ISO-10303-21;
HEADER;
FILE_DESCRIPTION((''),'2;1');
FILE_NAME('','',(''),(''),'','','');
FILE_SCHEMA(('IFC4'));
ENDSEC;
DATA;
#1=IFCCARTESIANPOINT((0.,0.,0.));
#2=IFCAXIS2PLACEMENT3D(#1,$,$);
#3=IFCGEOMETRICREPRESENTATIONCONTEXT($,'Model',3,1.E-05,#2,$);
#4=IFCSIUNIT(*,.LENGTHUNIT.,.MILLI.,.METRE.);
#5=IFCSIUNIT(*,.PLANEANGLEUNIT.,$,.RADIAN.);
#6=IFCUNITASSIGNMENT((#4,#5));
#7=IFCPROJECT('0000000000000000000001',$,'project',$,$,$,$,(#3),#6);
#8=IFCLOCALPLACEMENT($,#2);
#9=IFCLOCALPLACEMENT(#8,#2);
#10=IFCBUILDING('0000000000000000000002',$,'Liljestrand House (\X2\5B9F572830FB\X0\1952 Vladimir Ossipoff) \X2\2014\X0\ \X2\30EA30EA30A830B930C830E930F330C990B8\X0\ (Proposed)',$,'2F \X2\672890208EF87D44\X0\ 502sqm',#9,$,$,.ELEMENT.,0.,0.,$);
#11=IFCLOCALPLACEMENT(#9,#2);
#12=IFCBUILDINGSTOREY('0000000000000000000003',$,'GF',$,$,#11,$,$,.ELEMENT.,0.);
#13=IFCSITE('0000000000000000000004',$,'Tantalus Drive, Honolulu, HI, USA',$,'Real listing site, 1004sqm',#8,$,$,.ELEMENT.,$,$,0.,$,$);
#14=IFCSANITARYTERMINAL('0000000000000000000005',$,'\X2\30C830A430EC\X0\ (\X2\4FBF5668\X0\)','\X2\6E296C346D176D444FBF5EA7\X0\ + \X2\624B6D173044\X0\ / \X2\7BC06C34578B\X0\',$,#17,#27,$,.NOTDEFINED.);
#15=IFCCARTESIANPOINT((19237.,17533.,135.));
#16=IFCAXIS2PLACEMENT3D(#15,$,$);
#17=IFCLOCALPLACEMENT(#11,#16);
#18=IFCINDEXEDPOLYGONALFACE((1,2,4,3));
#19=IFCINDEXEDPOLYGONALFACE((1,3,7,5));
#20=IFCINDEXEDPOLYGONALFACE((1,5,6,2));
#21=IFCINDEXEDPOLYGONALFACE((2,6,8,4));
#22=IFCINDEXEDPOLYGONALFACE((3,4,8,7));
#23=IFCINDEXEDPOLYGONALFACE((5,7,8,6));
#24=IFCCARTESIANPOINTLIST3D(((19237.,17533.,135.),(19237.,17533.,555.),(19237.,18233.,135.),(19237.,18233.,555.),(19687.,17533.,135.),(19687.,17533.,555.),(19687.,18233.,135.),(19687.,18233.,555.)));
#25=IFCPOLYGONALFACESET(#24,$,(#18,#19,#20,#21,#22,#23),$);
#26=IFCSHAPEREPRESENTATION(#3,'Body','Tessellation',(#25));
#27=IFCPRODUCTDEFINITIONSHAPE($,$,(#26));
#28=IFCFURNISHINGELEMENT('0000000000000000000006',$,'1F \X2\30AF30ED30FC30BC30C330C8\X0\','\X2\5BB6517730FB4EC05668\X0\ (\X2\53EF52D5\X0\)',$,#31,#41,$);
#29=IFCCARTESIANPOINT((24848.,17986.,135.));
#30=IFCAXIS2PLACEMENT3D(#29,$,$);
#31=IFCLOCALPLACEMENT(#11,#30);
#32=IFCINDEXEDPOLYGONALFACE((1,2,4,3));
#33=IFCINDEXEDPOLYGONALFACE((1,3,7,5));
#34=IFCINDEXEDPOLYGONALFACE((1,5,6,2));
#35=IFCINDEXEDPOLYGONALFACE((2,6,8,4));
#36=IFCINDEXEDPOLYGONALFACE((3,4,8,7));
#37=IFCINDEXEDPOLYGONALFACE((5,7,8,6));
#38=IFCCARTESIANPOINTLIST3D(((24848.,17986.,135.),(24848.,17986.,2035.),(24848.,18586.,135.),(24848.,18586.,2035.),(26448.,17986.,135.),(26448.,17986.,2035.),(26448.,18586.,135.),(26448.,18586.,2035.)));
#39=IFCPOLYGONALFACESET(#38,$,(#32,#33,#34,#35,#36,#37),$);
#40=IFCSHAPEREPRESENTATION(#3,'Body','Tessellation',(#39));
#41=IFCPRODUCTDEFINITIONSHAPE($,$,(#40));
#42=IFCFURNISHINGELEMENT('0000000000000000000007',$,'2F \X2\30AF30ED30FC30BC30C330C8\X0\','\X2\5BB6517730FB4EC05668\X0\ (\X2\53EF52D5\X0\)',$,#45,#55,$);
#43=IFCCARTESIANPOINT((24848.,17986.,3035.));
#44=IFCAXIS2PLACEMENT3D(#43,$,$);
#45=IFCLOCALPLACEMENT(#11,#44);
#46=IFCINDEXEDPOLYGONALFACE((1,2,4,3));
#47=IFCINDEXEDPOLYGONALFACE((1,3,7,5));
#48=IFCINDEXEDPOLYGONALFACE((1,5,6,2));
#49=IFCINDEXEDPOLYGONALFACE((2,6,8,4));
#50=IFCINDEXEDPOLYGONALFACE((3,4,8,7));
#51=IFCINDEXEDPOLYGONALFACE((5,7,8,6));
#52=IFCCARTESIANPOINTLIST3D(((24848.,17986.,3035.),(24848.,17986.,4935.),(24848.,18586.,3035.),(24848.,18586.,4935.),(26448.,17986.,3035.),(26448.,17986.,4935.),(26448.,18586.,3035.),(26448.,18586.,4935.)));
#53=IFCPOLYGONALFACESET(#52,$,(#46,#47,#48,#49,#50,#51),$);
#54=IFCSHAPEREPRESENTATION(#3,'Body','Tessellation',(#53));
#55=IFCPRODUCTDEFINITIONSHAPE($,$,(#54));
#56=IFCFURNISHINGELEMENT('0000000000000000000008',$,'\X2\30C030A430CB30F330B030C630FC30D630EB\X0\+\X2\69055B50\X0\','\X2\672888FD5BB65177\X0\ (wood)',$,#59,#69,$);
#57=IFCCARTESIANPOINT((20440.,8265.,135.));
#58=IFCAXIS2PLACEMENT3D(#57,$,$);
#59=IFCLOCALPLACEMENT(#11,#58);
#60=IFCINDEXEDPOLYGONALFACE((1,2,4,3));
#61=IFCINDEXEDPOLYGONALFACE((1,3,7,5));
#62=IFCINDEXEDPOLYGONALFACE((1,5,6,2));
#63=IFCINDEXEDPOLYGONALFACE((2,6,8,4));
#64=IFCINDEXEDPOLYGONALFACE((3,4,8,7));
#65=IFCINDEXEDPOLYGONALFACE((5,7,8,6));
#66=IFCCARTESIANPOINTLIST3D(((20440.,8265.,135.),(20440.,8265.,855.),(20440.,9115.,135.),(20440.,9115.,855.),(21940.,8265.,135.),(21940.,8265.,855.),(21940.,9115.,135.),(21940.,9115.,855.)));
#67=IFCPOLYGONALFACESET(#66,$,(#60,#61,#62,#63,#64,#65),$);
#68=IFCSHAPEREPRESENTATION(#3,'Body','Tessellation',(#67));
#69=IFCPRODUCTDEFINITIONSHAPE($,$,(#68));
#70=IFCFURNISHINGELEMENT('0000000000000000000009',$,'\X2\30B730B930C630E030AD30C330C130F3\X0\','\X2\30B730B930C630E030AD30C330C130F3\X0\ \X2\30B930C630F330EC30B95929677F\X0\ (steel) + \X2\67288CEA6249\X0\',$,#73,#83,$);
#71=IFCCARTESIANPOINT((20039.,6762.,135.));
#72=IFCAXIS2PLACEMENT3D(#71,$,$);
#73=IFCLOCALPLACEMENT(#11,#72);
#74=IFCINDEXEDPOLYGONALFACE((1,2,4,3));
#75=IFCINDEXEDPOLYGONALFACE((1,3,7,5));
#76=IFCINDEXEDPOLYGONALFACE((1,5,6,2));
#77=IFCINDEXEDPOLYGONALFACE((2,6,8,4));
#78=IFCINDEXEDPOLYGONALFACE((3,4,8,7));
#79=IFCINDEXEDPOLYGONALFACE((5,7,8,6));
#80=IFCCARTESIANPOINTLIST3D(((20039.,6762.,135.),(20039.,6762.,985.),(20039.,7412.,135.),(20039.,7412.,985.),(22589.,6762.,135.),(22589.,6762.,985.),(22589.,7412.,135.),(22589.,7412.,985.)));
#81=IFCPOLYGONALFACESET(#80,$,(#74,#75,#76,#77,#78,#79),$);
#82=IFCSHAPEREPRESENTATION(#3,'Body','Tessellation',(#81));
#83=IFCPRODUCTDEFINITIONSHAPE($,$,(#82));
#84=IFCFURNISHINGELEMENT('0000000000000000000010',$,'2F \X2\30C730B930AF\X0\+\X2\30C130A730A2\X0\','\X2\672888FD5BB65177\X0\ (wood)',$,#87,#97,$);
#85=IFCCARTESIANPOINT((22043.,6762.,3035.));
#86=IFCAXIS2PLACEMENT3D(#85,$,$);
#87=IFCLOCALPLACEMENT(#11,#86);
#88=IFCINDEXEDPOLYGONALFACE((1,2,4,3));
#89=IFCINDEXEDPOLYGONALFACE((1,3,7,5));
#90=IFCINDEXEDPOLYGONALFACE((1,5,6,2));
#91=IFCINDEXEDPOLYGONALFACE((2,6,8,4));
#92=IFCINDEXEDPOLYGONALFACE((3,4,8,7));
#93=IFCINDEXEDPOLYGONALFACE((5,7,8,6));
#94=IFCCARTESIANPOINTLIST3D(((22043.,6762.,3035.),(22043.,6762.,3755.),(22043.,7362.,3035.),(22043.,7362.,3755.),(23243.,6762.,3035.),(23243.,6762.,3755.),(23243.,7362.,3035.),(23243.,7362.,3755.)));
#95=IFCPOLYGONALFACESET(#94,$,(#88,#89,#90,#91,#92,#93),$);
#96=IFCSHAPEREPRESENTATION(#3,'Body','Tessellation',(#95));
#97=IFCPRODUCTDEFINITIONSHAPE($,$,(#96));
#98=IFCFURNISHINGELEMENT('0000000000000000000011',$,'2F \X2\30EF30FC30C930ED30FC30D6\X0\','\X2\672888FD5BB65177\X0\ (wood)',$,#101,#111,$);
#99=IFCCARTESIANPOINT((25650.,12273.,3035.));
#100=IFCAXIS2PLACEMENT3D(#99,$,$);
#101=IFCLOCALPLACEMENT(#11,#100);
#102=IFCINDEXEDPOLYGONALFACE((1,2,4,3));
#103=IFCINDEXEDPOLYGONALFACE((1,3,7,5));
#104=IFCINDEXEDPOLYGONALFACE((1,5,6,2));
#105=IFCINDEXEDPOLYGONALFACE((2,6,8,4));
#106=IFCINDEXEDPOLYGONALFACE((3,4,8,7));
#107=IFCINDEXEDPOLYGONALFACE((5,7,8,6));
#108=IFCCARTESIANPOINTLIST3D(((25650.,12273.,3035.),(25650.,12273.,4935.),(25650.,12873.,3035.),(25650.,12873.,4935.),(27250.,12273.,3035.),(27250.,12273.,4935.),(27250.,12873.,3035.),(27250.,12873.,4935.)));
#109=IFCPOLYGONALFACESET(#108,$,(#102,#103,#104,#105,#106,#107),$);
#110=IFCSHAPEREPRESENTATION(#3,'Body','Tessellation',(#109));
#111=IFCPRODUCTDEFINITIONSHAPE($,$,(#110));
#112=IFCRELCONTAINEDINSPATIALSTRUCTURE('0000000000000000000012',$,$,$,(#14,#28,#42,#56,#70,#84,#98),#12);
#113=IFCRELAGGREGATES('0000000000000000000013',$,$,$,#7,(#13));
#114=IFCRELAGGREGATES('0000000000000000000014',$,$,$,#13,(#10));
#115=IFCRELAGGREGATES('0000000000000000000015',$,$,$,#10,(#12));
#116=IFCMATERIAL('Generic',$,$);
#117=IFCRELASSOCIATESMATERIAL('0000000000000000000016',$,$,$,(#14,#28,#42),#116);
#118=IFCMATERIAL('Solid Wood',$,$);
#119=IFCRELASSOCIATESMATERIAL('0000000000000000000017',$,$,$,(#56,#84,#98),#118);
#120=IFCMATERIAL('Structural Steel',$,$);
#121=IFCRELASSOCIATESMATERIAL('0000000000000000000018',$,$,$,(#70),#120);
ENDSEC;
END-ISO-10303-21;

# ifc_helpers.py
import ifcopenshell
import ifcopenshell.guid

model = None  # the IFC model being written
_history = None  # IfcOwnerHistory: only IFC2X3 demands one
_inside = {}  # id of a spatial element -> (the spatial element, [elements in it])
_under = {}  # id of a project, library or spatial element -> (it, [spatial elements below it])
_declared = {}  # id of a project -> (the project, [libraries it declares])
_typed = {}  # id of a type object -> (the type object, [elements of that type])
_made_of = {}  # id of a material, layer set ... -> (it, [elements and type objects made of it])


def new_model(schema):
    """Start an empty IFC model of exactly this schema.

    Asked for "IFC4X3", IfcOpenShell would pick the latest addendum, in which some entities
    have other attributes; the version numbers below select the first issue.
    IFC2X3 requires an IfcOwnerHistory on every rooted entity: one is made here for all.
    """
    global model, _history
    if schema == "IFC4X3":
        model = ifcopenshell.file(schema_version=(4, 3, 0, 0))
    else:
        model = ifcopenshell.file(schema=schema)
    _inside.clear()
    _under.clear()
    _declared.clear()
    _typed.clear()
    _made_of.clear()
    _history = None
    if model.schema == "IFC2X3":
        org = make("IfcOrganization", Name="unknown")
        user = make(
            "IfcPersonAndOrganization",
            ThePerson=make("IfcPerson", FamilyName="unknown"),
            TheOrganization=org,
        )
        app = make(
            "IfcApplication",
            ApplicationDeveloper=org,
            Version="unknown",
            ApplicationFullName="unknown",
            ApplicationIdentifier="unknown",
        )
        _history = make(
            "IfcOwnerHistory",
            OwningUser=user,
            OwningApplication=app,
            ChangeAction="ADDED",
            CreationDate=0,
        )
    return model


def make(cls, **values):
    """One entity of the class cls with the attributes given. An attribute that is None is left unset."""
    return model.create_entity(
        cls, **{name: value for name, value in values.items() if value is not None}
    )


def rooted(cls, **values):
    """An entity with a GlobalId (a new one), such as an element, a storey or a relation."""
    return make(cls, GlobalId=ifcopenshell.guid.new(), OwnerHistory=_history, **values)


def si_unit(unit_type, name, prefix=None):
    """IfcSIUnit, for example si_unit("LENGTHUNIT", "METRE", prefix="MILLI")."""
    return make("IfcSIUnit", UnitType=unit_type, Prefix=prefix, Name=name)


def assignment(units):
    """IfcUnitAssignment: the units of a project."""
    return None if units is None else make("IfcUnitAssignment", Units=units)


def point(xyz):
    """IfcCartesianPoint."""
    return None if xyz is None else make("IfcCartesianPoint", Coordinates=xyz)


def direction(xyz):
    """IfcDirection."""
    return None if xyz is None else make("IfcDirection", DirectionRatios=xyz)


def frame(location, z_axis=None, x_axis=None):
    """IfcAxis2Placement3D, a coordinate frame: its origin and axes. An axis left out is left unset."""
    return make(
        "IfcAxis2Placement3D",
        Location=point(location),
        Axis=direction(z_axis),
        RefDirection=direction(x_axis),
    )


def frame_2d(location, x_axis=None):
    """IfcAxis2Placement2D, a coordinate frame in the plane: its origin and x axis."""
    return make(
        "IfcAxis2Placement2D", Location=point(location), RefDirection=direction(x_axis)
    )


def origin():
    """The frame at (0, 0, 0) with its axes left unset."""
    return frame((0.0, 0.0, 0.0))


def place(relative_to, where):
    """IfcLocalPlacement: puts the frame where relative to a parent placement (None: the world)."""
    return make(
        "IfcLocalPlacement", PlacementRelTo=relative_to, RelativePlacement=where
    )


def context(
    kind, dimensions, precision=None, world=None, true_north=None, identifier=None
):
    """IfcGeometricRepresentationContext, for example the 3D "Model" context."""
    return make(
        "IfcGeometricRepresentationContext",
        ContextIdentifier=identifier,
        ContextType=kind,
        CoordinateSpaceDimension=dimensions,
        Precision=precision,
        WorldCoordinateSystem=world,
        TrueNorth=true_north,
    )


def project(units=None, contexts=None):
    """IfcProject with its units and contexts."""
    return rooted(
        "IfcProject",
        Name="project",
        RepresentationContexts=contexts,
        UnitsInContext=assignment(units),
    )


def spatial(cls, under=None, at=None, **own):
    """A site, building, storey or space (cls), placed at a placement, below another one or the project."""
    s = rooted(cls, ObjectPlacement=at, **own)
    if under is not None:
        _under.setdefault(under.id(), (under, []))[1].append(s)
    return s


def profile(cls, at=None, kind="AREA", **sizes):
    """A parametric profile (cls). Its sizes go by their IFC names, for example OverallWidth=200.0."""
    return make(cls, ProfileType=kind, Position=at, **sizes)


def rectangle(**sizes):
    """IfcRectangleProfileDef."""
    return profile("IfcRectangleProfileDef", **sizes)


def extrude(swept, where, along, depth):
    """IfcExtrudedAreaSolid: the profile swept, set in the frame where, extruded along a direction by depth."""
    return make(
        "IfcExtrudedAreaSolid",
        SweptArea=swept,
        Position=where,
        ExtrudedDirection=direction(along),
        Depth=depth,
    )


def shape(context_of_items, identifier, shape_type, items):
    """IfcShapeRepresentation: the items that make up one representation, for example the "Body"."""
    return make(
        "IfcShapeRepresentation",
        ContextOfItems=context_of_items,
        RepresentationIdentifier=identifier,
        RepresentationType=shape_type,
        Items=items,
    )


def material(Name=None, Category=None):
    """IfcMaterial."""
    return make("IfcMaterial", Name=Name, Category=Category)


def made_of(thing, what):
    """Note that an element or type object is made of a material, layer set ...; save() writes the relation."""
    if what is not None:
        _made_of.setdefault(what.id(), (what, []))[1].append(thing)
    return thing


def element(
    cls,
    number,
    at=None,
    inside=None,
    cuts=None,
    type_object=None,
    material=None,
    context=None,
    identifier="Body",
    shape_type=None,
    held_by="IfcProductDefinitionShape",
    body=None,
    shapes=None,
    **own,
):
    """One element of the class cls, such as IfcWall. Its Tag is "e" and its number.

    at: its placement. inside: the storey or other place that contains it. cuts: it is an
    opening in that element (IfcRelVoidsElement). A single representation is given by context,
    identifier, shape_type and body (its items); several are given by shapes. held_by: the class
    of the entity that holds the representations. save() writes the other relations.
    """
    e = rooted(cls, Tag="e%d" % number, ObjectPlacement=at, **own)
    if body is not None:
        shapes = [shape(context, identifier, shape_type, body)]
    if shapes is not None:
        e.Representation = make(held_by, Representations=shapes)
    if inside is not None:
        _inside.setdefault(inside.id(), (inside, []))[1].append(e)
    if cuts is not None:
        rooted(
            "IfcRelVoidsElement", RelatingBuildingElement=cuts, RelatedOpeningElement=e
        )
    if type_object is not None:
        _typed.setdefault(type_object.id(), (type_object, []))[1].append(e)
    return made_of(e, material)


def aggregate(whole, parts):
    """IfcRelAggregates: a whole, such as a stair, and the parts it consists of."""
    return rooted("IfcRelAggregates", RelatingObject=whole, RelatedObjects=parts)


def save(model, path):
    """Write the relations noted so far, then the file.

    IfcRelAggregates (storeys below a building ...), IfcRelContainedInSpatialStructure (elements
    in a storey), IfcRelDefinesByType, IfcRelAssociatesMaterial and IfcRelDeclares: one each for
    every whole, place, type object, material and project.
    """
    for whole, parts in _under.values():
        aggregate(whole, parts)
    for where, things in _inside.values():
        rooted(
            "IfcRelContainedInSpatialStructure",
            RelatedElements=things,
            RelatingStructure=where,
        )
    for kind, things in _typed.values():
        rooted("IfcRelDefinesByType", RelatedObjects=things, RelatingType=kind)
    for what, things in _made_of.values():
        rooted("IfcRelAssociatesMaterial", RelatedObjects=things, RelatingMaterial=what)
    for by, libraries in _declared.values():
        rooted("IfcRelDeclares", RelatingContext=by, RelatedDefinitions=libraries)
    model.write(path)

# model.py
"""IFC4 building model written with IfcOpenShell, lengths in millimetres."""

from ifc_helpers import new_model, si_unit, frame, frame_2d, origin, place, context, project, spatial, rectangle, extrude, material, element, save


model = new_model("IFC4")

# Units and contexts
model_context = context("Model", 3, precision=1e-05, world=origin())
ifc_project = project(units=[si_unit("LENGTHUNIT", "METRE", prefix="MILLI"), si_unit("PLANEANGLEUNIT", "RADIAN")], contexts=[model_context])

# Site, building, storey
site_placement = place(None, origin())
site = spatial("IfcSite", under=ifc_project, at=site_placement, Name="Tantalus Drive, Honolulu, HI, USA", ObjectType="Real listing site, 1004sqm", CompositionType="ELEMENT", RefElevation=0.0)
building_placement = place(site_placement, origin())
building = spatial("IfcBuilding", under=site, at=building_placement, Name="Liljestrand House (実在・1952 Vladimir Ossipoff) — リリエストランド邸 (Proposed)", ObjectType="2F 木造軸組 502sqm", CompositionType="ELEMENT", ElevationOfRefHeight=0.0, ElevationOfTerrain=0.0)
storey_placement = place(building_placement, origin())
storey = spatial("IfcBuildingStorey", under=building, at=storey_placement, Name="GF", CompositionType="ELEMENT", Elevation=0.0)

# Shared definitions
ifc_material_1 = material(Name="Solid Wood")

# Shared definitions
ifc_material_2 = material(Name="Structural Steel")

# Sanitary terminal
ifc_material_3 = material(Name="Generic")
sanitary_terminal_1_placement = place(storey_placement, frame((19237.0, 17533.0, 135.0)))
element("IfcSanitaryTerminal", 1, at=sanitary_terminal_1_placement, inside=storey, material=ifc_material_3, Name="トイレ (便器)", Description="温水洗浄便座 + 手洗い / 節水型", PredefinedType="NOTDEFINED", context=model_context, shape_type="SweptSolid", body=[
    extrude(rectangle(XDim=450.0, YDim=700.0, at=frame_2d((225.0, 350.0))), frame((19237.0, 17533.0, 135.0)), (0.0, 0.0, 1.0), 420.0),
])

# Furnishing elements
furnishing_1_placement = place(storey_placement, frame((24848.0, 17986.0, 135.0)))
element("IfcFurnishingElement", 2, at=furnishing_1_placement, inside=storey, material=ifc_material_3, Name="1F クローゼット", Description="家具・什器 (可動)", context=model_context, shape_type="SweptSolid", body=[
    extrude(rectangle(XDim=1600.0, YDim=600.0, at=frame_2d((800.0, 300.0))), frame((24848.0, 17986.0, 135.0)), (0.0, 0.0, 1.0), 1900.0),
])
furnishing_2_placement = place(storey_placement, frame((24848.0, 17986.0, 3035.0)))
element("IfcFurnishingElement", 3, at=furnishing_2_placement, inside=storey, material=ifc_material_3, Name="2F クローゼット", Description="家具・什器 (可動)", context=model_context, shape_type="SweptSolid", body=[
    extrude(rectangle(XDim=1600.0, YDim=600.0, at=frame_2d((800.0, 300.0))), frame((24848.0, 17986.0, 3035.0)), (0.0, 0.0, 1.0), 1900.0),
])
furnishing_3_placement = place(storey_placement, frame((20440.0, 8265.0, 135.0)))
element("IfcFurnishingElement", 4, at=furnishing_3_placement, inside=storey, material=ifc_material_1, Name="ダイニングテーブル+椅子", Description="木製家具 (wood)", context=model_context, shape_type="SweptSolid", body=[
    extrude(rectangle(XDim=1500.0, YDim=850.0, at=frame_2d((750.0, 425.0))), frame((20440.0, 8265.0, 135.0)), (0.0, 0.0, 1.0), 720.0),
])
furnishing_4_placement = place(storey_placement, frame((20039.0, 6762.0, 135.0)))
element("IfcFurnishingElement", 5, at=furnishing_4_placement, inside=storey, material=ifc_material_2, Name="システムキッチン", Description="システムキッチン ステンレス天板 (steel) + 木質扉", context=model_context, shape_type="SweptSolid", body=[
    extrude(rectangle(XDim=2550.0, YDim=650.0, at=frame_2d((1275.0, 325.0))), frame((20039.0, 6762.0, 135.0)), (0.0, 0.0, 1.0), 850.0),
])
furnishing_5_placement = place(storey_placement, frame((22043.0, 6762.0, 3035.0)))
element("IfcFurnishingElement", 6, at=furnishing_5_placement, inside=storey, material=ifc_material_1, Name="2F デスク+チェア", Description="木製家具 (wood)", context=model_context, shape_type="SweptSolid", body=[
    extrude(rectangle(XDim=1200.0, YDim=600.0, at=frame_2d((600.0, 300.0))), frame((22043.0, 6762.0, 3035.0)), (0.0, 0.0, 1.0), 720.0),
])
furnishing_6_placement = place(storey_placement, frame((25650.0, 12273.0, 3035.0)))
element("IfcFurnishingElement", 7, at=furnishing_6_placement, inside=storey, material=ifc_material_1, Name="2F ワードローブ", Description="木製家具 (wood)", context=model_context, shape_type="SweptSolid", body=[
    extrude(rectangle(XDim=1600.0, YDim=600.0, at=frame_2d((800.0, 300.0))), frame((25650.0, 12273.0, 3035.0)), (0.0, 0.0, 1.0), 1900.0),
])

save(model, "model.ifc")
